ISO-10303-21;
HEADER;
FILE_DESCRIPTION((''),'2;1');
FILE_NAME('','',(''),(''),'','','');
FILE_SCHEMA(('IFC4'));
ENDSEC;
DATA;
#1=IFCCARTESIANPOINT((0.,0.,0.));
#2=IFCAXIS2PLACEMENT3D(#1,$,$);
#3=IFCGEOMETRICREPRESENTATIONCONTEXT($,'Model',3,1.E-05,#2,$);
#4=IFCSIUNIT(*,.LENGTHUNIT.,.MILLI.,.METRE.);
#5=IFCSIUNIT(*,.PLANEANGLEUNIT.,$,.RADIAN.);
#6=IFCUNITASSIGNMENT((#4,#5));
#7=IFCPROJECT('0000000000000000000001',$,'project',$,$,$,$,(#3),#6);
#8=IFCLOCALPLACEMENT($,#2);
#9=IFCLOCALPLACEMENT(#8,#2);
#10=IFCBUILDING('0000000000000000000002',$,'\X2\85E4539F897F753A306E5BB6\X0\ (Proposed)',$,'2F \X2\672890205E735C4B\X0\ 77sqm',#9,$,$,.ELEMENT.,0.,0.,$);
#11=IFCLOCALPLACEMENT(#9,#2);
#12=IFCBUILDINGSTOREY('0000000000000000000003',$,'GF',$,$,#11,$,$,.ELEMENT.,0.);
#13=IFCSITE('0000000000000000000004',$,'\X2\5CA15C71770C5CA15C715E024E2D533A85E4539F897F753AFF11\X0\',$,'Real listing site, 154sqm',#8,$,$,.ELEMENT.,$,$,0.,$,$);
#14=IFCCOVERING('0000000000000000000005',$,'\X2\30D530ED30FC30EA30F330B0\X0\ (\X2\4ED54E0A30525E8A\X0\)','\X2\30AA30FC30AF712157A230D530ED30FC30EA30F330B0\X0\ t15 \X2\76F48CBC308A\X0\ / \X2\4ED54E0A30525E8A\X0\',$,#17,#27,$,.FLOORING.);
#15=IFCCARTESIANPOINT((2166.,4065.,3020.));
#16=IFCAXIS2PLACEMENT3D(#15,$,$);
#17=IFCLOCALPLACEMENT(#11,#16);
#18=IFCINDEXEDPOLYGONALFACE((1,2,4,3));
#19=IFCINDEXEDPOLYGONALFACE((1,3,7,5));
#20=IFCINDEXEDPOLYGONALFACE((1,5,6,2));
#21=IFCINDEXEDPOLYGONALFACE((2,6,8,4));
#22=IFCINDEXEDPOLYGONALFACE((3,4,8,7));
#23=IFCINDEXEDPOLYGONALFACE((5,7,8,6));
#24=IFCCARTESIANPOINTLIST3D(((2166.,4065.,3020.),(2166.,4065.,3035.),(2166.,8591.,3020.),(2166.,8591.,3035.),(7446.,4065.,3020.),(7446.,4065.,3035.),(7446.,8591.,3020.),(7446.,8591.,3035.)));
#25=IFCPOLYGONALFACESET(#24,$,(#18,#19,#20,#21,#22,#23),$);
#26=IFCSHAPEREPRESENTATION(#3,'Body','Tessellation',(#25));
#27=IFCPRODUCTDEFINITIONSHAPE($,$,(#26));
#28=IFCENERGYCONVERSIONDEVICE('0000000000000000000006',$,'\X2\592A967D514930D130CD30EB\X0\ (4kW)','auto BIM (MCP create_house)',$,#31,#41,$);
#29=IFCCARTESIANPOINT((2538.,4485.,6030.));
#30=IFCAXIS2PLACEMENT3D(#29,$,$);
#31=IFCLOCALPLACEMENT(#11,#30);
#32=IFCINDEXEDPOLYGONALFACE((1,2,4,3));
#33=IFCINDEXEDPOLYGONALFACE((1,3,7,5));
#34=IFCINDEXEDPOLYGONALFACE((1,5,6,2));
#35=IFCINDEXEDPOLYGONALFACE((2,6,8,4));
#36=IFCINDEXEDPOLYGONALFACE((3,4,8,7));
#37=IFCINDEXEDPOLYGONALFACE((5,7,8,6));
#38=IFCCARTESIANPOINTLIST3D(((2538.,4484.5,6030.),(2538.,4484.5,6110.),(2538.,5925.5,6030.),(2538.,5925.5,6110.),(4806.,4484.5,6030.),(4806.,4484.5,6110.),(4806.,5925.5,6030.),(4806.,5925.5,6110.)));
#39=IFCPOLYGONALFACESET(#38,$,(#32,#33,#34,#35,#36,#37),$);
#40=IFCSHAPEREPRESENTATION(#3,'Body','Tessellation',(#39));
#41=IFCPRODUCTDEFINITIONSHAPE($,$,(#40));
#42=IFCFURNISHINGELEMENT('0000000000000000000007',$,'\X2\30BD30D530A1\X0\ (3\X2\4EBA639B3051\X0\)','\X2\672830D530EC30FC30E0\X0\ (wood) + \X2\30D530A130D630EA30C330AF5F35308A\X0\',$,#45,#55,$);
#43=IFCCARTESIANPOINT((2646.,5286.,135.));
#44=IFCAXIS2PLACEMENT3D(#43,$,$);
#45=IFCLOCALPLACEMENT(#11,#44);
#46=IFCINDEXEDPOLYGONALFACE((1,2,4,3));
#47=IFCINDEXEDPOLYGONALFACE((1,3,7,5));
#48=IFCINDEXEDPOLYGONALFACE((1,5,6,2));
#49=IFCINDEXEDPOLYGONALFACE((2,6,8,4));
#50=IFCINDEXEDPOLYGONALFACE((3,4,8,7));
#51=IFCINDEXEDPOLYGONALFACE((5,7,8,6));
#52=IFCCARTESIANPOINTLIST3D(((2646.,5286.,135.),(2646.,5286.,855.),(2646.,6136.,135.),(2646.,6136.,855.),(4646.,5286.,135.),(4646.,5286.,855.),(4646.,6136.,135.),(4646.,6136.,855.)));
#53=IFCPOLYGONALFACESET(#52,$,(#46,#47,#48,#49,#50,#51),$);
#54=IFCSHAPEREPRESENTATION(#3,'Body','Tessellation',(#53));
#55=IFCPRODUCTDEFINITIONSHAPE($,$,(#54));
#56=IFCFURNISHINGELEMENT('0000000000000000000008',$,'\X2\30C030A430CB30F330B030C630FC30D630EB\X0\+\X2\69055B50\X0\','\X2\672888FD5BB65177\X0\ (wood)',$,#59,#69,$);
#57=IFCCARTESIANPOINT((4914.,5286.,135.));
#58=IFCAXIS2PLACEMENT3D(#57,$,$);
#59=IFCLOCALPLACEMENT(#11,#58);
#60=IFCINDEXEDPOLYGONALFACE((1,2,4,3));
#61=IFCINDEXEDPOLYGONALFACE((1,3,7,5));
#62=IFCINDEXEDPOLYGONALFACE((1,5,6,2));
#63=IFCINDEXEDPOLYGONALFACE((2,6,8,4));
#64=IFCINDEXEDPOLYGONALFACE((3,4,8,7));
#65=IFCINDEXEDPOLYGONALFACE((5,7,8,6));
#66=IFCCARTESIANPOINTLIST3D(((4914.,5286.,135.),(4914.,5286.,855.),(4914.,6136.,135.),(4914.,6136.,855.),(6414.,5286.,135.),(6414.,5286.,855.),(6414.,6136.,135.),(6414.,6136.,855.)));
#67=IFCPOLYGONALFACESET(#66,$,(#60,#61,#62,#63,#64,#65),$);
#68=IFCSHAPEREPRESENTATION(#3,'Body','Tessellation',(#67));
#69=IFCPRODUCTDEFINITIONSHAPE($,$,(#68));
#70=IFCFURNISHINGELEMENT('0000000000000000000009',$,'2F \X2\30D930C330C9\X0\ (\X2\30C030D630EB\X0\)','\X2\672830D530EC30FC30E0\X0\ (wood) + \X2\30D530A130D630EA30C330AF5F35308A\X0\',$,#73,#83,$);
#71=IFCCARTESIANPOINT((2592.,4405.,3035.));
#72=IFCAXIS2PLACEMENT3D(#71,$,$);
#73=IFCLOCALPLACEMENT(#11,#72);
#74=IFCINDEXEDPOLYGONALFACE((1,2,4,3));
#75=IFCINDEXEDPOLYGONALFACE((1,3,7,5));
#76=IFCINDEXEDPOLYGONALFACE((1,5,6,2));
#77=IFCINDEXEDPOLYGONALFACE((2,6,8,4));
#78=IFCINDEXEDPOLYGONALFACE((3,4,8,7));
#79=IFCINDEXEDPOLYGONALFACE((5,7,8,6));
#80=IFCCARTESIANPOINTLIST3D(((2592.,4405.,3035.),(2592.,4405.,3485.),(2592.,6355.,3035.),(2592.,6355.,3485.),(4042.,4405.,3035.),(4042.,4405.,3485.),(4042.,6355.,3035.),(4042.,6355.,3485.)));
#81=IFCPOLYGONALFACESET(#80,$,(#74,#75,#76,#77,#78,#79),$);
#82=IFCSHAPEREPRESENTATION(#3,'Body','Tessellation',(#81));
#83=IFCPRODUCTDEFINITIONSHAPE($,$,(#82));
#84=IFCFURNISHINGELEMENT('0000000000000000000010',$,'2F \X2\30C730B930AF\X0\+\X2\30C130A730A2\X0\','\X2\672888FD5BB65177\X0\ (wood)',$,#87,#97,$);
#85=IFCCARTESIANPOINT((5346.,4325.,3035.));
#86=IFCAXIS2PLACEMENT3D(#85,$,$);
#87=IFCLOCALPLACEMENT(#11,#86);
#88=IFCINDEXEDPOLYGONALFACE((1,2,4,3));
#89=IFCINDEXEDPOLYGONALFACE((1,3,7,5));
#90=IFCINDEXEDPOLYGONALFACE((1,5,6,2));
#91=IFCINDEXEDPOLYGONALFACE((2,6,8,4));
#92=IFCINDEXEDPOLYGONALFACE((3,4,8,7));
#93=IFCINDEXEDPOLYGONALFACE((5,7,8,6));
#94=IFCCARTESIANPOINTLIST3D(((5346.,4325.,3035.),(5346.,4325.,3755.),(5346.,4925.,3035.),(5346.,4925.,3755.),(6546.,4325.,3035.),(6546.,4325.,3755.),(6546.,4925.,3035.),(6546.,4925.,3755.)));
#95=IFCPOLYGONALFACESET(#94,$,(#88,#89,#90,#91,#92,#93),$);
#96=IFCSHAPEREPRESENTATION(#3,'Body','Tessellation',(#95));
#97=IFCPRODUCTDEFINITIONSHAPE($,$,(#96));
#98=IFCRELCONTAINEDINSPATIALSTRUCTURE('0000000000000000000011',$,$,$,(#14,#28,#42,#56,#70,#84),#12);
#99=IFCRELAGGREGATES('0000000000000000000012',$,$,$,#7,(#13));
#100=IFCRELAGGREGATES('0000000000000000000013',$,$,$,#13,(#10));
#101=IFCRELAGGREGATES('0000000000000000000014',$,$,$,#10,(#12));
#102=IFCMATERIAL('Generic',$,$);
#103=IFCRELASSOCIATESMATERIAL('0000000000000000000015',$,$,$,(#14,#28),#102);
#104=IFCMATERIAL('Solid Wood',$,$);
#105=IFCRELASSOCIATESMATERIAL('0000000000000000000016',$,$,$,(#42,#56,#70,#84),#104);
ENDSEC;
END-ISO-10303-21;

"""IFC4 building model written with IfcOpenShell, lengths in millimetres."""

from ifc_helpers import new_model, si_unit, frame, frame_2d, origin, place, context, project, spatial, rectangle, extrude, material, element, save


model = new_model("IFC4")

# Units and contexts
model_context = context("Model", 3, precision=1e-05, world=origin())
ifc_project = project(units=[si_unit("LENGTHUNIT", "METRE", prefix="MILLI"), si_unit("PLANEANGLEUNIT", "RADIAN")], contexts=[model_context])

# Site, building, storey
site_placement = place(None, origin())
site = spatial("IfcSite", under=ifc_project, at=site_placement, Name="岡山県岡山市中区藤原西町１", ObjectType="Real listing site, 154sqm", CompositionType="ELEMENT", RefElevation=0.0)
building_placement = place(site_placement, origin())
building = spatial("IfcBuilding", under=site, at=building_placement, Name="藤原西町の家 (Proposed)", ObjectType="2F 木造平屋 77sqm", CompositionType="ELEMENT", ElevationOfRefHeight=0.0, ElevationOfTerrain=0.0)
storey_placement = place(building_placement, origin())
storey = spatial("IfcBuildingStorey", under=building, at=storey_placement, Name="GF", CompositionType="ELEMENT", Elevation=0.0)

# Shared definitions
ifc_material_1 = material(Name="Solid Wood")

# Covering
ifc_material_2 = material(Name="Generic")
covering_placement = place(storey_placement, frame((2166.0, 4065.0, 3020.0)))
element("IfcCovering", 1, at=covering_placement, inside=storey, material=ifc_material_2, Name="フローリング (仕上げ床)", Description="オーク無垢フローリング t15 直貼り / 仕上げ床", PredefinedType="FLOORING", context=model_context, shape_type="SweptSolid", body=[
    extrude(rectangle(XDim=5280.0, YDim=4526.0, at=frame_2d((2640.0, 2263.0))), frame((2166.0, 4065.0, 3020.0)), (0.0, 0.0, 1.0), 15.0),
])

# Energy conversion device
energy_conversion_device_placement = place(storey_placement, frame((2538.0, 4485.0, 6030.0)))
element("IfcEnergyConversionDevice", 2, at=energy_conversion_device_placement, inside=storey, material=ifc_material_2, Name="太陽光パネル (4kW)", Description="auto BIM (MCP create_house)", context=model_context, shape_type="SweptSolid", body=[
    extrude(rectangle(XDim=2268.0, YDim=1441.0, at=frame_2d((1134.0, 720.0))), frame((2538.0, 4485.0, 6030.0)), (0.0, 0.0, 1.0), 80.0),
])

# Furnishing elements
furnishing_1_placement = place(storey_placement, frame((2646.0, 5286.0, 135.0)))
element("IfcFurnishingElement", 3, at=furnishing_1_placement, inside=storey, material=ifc_material_1, Name="ソファ (3人掛け)", Description="木フレーム (wood) + ファブリック張り", context=model_context, shape_type="SweptSolid", body=[
    extrude(rectangle(XDim=2000.0, YDim=850.0, at=frame_2d((1000.0, 425.0))), frame((2646.0, 5286.0, 135.0)), (0.0, 0.0, 1.0), 720.0),
])
furnishing_2_placement = place(storey_placement, frame((4914.0, 5286.0, 135.0)))
element("IfcFurnishingElement", 4, at=furnishing_2_placement, inside=storey, material=ifc_material_1, Name="ダイニングテーブル+椅子", Description="木製家具 (wood)", context=model_context, shape_type="SweptSolid", body=[
    extrude(rectangle(XDim=1500.0, YDim=850.0, at=frame_2d((750.0, 425.0))), frame((4914.0, 5286.0, 135.0)), (0.0, 0.0, 1.0), 720.0),
])
furnishing_3_placement = place(storey_placement, frame((2592.0, 4405.0, 3035.0)))
element("IfcFurnishingElement", 5, at=furnishing_3_placement, inside=storey, material=ifc_material_1, Name="2F ベッド (ダブル)", Description="木フレーム (wood) + ファブリック張り", context=model_context, shape_type="SweptSolid", body=[
    extrude(rectangle(XDim=1450.0, YDim=1950.0, at=frame_2d((725.0, 975.0))), frame((2592.0, 4405.0, 3035.0)), (0.0, 0.0, 1.0), 450.0),
])
furnishing_4_placement = place(storey_placement, frame((5346.0, 4325.0, 3035.0)))
element("IfcFurnishingElement", 6, at=furnishing_4_placement, inside=storey, material=ifc_material_1, Name="2F デスク+チェア", Description="木製家具 (wood)", context=model_context, shape_type="SweptSolid", body=[
    extrude(rectangle(XDim=1200.0, YDim=600.0, at=frame_2d((600.0, 300.0))), frame((5346.0, 4325.0, 3035.0)), (0.0, 0.0, 1.0), 720.0),
])

save(model, "model.ifc")
